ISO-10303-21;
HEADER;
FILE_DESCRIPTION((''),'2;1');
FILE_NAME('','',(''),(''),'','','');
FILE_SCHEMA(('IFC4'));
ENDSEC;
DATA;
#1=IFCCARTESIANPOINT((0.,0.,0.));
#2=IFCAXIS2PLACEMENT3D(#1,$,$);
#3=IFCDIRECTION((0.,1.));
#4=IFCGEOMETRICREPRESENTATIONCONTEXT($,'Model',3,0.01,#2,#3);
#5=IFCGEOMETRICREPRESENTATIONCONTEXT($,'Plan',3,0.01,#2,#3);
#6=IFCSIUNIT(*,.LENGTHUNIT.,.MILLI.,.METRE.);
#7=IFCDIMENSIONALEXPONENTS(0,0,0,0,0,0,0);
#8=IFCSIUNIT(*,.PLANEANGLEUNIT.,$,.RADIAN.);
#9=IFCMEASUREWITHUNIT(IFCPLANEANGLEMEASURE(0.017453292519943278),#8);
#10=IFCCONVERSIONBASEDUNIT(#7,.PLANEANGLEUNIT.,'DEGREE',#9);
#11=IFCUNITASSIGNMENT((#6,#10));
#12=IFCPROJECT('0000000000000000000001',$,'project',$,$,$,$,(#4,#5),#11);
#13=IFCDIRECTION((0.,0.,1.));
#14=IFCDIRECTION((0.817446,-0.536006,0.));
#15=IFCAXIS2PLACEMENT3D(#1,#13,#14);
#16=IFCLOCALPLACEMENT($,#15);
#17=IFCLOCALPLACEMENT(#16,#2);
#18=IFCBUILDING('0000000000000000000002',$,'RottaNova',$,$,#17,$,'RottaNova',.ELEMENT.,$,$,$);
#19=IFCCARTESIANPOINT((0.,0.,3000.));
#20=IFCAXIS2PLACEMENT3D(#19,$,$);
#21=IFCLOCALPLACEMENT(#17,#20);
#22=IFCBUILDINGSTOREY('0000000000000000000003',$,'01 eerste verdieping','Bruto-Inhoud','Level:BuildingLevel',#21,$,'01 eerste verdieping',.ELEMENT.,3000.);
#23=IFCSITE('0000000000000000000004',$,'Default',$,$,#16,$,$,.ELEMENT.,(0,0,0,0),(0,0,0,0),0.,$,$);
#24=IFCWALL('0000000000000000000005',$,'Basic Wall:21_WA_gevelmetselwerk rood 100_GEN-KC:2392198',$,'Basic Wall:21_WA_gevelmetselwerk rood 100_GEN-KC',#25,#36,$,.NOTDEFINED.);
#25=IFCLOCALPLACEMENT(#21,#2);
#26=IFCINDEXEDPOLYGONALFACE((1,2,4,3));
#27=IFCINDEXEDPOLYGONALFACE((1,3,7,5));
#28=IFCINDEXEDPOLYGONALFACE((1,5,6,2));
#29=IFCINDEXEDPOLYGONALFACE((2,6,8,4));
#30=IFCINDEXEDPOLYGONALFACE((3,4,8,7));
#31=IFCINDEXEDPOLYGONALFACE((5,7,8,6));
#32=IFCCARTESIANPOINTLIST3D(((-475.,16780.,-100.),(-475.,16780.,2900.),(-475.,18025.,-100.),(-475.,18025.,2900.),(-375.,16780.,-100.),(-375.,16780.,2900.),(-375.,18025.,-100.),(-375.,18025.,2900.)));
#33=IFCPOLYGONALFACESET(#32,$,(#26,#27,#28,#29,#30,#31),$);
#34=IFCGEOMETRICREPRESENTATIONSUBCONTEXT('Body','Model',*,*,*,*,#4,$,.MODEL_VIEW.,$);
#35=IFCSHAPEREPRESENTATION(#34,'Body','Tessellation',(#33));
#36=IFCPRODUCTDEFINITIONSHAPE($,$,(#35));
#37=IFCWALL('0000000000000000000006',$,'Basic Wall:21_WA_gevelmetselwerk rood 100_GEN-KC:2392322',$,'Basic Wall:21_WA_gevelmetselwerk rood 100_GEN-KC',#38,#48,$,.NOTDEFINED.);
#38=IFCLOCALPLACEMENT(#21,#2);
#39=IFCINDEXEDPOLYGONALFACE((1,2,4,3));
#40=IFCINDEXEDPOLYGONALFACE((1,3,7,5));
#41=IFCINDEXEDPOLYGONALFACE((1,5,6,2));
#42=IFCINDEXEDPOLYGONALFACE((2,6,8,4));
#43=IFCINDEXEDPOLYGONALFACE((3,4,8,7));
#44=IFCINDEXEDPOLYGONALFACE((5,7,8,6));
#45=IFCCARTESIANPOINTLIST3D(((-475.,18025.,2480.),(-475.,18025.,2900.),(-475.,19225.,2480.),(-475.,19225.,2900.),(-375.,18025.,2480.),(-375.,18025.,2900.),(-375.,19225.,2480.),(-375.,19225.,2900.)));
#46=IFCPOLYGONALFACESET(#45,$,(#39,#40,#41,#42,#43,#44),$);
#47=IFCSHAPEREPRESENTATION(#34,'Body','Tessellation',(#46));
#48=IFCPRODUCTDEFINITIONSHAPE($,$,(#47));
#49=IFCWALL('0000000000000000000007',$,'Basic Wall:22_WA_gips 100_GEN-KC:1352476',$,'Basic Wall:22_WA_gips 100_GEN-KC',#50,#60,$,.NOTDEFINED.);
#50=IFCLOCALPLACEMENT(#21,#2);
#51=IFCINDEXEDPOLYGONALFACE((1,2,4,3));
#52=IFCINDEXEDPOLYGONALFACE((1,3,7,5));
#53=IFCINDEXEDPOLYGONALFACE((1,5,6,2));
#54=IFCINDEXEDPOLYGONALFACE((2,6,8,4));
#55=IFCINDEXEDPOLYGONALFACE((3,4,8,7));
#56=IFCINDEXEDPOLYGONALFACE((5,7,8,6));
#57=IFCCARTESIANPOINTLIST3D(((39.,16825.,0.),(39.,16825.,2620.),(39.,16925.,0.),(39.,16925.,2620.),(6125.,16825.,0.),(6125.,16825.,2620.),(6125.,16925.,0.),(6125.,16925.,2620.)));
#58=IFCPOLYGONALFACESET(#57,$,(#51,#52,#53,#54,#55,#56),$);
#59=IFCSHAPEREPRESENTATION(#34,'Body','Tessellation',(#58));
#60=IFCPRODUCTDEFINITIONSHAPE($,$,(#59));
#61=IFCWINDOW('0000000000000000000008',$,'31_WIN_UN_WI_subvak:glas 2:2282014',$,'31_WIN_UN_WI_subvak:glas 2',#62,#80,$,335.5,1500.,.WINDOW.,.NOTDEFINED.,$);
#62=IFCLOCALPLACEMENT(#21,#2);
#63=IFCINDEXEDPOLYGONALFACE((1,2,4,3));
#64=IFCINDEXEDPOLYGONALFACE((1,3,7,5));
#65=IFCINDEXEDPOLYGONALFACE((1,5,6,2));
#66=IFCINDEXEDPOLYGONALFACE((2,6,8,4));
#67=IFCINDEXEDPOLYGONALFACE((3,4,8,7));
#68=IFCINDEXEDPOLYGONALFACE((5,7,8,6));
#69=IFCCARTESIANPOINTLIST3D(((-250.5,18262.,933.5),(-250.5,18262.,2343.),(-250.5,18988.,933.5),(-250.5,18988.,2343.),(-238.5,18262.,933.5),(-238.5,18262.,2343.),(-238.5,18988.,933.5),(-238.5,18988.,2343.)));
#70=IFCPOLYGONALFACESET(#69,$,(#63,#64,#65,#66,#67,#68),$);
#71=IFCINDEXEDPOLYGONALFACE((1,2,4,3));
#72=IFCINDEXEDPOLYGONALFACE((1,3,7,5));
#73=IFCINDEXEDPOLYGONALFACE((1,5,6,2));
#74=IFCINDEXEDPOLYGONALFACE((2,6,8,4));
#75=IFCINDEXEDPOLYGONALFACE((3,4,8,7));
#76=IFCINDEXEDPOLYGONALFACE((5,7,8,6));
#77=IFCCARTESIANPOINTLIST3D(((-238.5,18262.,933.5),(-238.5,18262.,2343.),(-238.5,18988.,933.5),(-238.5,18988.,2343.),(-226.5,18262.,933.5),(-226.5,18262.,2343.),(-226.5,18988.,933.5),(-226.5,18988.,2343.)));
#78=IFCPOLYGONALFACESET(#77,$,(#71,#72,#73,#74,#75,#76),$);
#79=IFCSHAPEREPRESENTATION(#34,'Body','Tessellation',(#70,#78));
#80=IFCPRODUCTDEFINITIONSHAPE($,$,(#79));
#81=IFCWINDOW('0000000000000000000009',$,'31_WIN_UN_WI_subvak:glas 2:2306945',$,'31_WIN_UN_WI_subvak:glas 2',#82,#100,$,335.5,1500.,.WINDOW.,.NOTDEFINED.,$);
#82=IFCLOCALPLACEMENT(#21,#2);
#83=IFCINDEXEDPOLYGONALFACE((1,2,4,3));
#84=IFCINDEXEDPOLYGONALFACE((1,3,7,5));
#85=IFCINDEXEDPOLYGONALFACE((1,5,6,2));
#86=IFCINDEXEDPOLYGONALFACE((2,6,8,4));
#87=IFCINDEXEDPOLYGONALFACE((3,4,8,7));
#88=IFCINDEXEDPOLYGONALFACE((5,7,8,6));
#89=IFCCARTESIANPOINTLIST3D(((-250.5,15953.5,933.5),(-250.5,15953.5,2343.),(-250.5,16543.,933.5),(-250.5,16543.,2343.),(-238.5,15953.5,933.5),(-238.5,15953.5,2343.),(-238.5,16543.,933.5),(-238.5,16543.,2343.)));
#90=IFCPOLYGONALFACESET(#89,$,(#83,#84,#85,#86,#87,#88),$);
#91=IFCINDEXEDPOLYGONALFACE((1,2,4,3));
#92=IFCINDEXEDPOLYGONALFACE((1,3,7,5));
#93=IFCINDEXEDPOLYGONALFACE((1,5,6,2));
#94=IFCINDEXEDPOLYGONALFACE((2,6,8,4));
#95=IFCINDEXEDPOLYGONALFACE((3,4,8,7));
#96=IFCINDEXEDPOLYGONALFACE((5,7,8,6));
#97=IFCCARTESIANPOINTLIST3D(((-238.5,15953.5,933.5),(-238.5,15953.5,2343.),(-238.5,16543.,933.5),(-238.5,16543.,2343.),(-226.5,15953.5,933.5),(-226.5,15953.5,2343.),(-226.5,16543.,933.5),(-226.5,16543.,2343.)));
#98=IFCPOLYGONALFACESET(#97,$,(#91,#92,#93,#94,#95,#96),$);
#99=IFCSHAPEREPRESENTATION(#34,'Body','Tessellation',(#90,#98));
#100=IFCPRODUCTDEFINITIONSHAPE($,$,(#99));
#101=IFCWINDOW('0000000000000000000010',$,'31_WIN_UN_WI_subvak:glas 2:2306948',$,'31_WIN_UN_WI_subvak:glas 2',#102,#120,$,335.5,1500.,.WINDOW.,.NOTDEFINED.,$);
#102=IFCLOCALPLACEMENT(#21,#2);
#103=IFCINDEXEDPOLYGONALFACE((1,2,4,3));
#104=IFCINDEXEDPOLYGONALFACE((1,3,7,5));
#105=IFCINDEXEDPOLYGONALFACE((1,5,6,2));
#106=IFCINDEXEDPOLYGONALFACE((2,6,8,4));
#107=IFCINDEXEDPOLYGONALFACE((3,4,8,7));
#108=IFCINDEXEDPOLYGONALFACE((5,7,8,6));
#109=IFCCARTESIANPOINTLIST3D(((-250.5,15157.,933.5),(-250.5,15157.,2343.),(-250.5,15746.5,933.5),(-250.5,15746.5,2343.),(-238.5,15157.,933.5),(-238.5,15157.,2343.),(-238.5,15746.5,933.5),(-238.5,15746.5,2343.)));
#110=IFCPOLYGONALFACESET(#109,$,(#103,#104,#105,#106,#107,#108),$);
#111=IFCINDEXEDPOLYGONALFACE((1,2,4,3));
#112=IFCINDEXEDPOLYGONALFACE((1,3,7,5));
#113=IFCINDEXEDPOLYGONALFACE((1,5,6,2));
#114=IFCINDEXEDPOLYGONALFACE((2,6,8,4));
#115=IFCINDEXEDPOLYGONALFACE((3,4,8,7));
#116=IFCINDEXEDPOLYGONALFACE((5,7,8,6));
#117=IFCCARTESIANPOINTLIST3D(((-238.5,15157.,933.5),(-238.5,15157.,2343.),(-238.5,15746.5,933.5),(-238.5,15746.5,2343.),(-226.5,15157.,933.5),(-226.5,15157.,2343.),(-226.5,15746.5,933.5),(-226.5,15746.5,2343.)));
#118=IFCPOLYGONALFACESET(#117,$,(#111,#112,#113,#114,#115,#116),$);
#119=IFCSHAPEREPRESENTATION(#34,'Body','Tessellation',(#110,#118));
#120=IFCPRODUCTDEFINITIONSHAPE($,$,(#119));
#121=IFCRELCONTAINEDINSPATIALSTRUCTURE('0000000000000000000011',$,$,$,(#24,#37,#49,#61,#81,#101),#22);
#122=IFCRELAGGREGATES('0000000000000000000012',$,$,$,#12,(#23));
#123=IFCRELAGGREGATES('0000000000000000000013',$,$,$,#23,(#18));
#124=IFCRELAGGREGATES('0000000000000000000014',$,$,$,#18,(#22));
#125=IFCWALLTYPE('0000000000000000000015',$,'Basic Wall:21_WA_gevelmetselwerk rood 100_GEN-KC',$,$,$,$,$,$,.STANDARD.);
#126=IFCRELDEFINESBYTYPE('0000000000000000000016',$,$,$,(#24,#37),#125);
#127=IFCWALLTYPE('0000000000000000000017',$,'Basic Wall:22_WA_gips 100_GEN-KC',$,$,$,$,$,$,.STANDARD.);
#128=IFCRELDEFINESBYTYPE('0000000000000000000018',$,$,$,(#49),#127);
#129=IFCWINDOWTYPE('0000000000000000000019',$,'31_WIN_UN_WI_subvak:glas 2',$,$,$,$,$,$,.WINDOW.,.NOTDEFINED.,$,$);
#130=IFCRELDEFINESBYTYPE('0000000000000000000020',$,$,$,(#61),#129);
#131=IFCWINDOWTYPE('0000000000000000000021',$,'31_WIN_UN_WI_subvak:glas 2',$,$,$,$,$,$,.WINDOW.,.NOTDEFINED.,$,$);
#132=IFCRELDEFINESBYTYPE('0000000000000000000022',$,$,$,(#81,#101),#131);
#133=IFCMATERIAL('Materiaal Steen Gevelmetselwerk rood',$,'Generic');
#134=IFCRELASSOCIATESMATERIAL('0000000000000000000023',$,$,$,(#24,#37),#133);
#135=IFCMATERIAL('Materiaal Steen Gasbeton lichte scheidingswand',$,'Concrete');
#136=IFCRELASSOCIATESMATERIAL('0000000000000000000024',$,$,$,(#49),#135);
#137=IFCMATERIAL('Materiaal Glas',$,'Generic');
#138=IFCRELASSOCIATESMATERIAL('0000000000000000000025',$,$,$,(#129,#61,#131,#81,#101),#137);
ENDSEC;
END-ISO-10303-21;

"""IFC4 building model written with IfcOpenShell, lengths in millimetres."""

from ifc_helpers import new_model, entity, si_unit, converted_unit, direction, frame, origin, place, context, subcontext, project, spatial, indexed_curve, outline, extrude, source, transform, mapped, material, type_object, type_shapes, element, save


model = new_model("IFC4")

# Units and contexts
model_context = context("Model", 3, precision=0.01, world=origin(), true_north=direction((0.0, 1.0)))
plan_context = context("Plan", 3, precision=0.01, world=origin(), true_north=direction((0.0, 1.0)))
body_context = subcontext(model_context, "Body", "Model", "MODEL_VIEW")
ifc_project = project(units=[si_unit("LENGTHUNIT", "METRE", prefix="MILLI"), converted_unit("PLANEANGLEUNIT", "DEGREE", entity("IfcPlaneAngleMeasure", 0.017453292519943278), si_unit("PLANEANGLEUNIT", "RADIAN"), dimensions=[0, 0, 0, 0, 0, 0, 0])], contexts=[model_context, plan_context])

# Site, building, storey
site_placement = place(None, frame((0.0, 0.0, 0.0), z_axis=(0.0, 0.0, 1.0), x_axis=(0.817446, -0.536006, 0.0)))
site = spatial("IfcSite", under=ifc_project, at=site_placement, Name="Default", CompositionType="ELEMENT", RefLatitude=(0, 0, 0, 0), RefLongitude=(0, 0, 0, 0), RefElevation=0.0)
building_placement = place(site_placement, origin())
building = spatial("IfcBuilding", under=site, at=building_placement, Name="RottaNova", LongName="RottaNova", CompositionType="ELEMENT")
storey_placement = place(building_placement, frame((0.0, 0.0, 3000.0)))
storey = spatial("IfcBuildingStorey", under=building, at=storey_placement, Name="01 eerste verdieping", Description="Bruto-Inhoud", ObjectType="Level:BuildingLevel", LongName="01 eerste verdieping", CompositionType="ELEMENT", Elevation=3000.0)

# Shared definitions
ifc_material_1 = material(Name="Materiaal Glas", Category="Generic")

# Walls
ifc_material_2 = material(Name="Materiaal Steen Gevelmetselwerk rood", Category="Generic")
wall_type_1 = type_object("IfcWallType", Name="Basic Wall:21_WA_gevelmetselwerk rood 100_GEN-KC", PredefinedType="STANDARD")
wall_1_placement = place(storey_placement, frame((-425.0, 16780.0, -100.0), z_axis=(0.0, 0.0, 1.0), x_axis=(0.0, 1.0, 0.0)))
element("IfcWall", 1, at=wall_1_placement, inside=storey, type_object=wall_type_1, material=ifc_material_2, Name="Basic Wall:21_WA_gevelmetselwerk rood 100_GEN-KC:2392198", ObjectType="Basic Wall:21_WA_gevelmetselwerk rood 100_GEN-KC", PredefinedType="NOTDEFINED", context=body_context, shape_type="SweptSolid", body=[
    extrude(outline(indexed_curve([(1245.0, 50.0), (0.0, 50.0), (0.0, -50.0), (1245.0, -50.0), (1245.0, 50.0)], self_intersect=False)), origin(), (0.0, 0.0, 1.0), 3000.0),
])
wall_2_placement = place(storey_placement, frame((-425.0, 19225.0, 2480.0), z_axis=(0.0, 0.0, 1.0), x_axis=(0.0, -1.0, 0.0)))
element("IfcWall", 2, at=wall_2_placement, inside=storey, type_object=wall_type_1, material=ifc_material_2, Name="Basic Wall:21_WA_gevelmetselwerk rood 100_GEN-KC:2392322", ObjectType="Basic Wall:21_WA_gevelmetselwerk rood 100_GEN-KC", PredefinedType="NOTDEFINED", context=body_context, shape_type="SweptSolid", body=[
    extrude(outline(indexed_curve([(1200.0, 50.0), (0.0, 50.0), (0.0, -50.0), (1200.0, -50.0), (1200.0, 50.0)], self_intersect=False)), origin(), (0.0, 0.0, 1.0), 420.0),
])
ifc_material_3 = material(Name="Materiaal Steen Gasbeton lichte scheidingswand", Category="Concrete")
wall_type_2 = type_object("IfcWallType", Name="Basic Wall:22_WA_gips 100_GEN-KC", PredefinedType="STANDARD")
wall_3_placement = place(storey_placement, frame((39.0, 16875.0, 0.0)))
element("IfcWall", 3, at=wall_3_placement, inside=storey, type_object=wall_type_2, material=ifc_material_3, Name="Basic Wall:22_WA_gips 100_GEN-KC:1352476", ObjectType="Basic Wall:22_WA_gips 100_GEN-KC", PredefinedType="NOTDEFINED", context=body_context, shape_type="SweptSolid", body=[
    extrude(outline(indexed_curve([(6086.0, 50.0), (0.0, 50.0), (0.0, -50.0), (6086.0, -50.0), (6086.0, 50.0)], self_intersect=False)), origin(), (0.0, 0.0, 1.0), 2620.0),
])

# Windows
window_type_1 = type_object("IfcWindowType", Name="31_WIN_UN_WI_subvak:glas 2", PartitioningType="NOTDEFINED", PredefinedType="WINDOW", material=ifc_material_1)
shared_shape_1 = source(origin(), body_context, "Body", "SweptSolid", [
    extrude(outline(indexed_curve([(-6.0, -363.0), (6.0, -363.0), (6.0, 363.0), (-6.0, 363.0), (-6.0, -363.0)], self_intersect=False)), frame((0.0, 6.0, 0.0), z_axis=(0.0, 0.0, 1.0), x_axis=(0.0, -1.0, 0.0)), (0.0, 0.0, 1.0), 1409.5),
    extrude(outline(indexed_curve([(-6.0, -363.0), (6.0, -363.0), (6.0, 363.0), (-6.0, 363.0), (-6.0, -363.0)], self_intersect=False)), frame((0.0, -6.0, 0.0), z_axis=(0.0, 0.0, 1.0), x_axis=(0.0, -1.0, 0.0)), (0.0, 0.0, 1.0), 1409.5),
])
type_shapes(window_type_1, [shared_shape_1])
window_1_placement = place(storey_placement, frame((-238.5, 18625.0, 933.5), z_axis=(0.0, 0.0, 1.0), x_axis=(0.0, 1.0, 0.0)))
element("IfcWindow", 4, at=window_1_placement, inside=storey, type_object=window_type_1, material=ifc_material_1, Name="31_WIN_UN_WI_subvak:glas 2:2282014", ObjectType="31_WIN_UN_WI_subvak:glas 2", OverallHeight=335.5, OverallWidth=1500.0, PartitioningType="NOTDEFINED", PredefinedType="WINDOW", context=body_context, shape_type="MappedRepresentation", body=[
    mapped(shared_shape_1, transform((0.0, 0.0, 0.0), scale=1.0)),
])
window_type_2 = type_object("IfcWindowType", Name="31_WIN_UN_WI_subvak:glas 2", PartitioningType="NOTDEFINED", PredefinedType="WINDOW", material=ifc_material_1)
shared_shape_2 = source(origin(), body_context, "Body", "SweptSolid", [
    extrude(outline(indexed_curve([(-294.7, -6.0), (294.7, -6.0), (294.7, 6.0), (-294.7, 6.0), (-294.7, -6.0)], self_intersect=False)), frame((0.0, -6.0, 0.0)), (0.0, 0.0, 1.0), 1409.5),
    extrude(outline(indexed_curve([(-294.8, -6.0), (294.8, -6.0), (294.8, 6.0), (-294.8, 6.0), (-294.8, -6.0)], self_intersect=False)), frame((0.0, 6.0, 0.0)), (0.0, 0.0, 1.0), 1409.5),
])
type_shapes(window_type_2, [shared_shape_2])
for number, where, z_axis, x_axis, name in (
    (5, (-238.5, 16248.2, 933.5), (0.0, 0.0, 1.0), (0.0, -1.0, 0.0), "31_WIN_UN_WI_subvak:glas 2:2306945"),
    (6, (-238.5, 15451.7, 933.5), (0.0, 0.0, 1.0), (0.0, -1.0, 0.0), "31_WIN_UN_WI_subvak:glas 2:2306948"),
):
    element("IfcWindow", number, at=place(storey_placement, frame(where, z_axis=z_axis, x_axis=x_axis)), inside=storey, type_object=window_type_2, material=ifc_material_1, Name=name, ObjectType="31_WIN_UN_WI_subvak:glas 2", OverallHeight=335.5, OverallWidth=1500.0, PartitioningType="NOTDEFINED", PredefinedType="WINDOW", context=body_context, shape_type="MappedRepresentation", body=[
        mapped(shared_shape_2, transform((0.0, 0.0, 0.0), scale=1.0)),
    ])

save(model, "model.ifc")
